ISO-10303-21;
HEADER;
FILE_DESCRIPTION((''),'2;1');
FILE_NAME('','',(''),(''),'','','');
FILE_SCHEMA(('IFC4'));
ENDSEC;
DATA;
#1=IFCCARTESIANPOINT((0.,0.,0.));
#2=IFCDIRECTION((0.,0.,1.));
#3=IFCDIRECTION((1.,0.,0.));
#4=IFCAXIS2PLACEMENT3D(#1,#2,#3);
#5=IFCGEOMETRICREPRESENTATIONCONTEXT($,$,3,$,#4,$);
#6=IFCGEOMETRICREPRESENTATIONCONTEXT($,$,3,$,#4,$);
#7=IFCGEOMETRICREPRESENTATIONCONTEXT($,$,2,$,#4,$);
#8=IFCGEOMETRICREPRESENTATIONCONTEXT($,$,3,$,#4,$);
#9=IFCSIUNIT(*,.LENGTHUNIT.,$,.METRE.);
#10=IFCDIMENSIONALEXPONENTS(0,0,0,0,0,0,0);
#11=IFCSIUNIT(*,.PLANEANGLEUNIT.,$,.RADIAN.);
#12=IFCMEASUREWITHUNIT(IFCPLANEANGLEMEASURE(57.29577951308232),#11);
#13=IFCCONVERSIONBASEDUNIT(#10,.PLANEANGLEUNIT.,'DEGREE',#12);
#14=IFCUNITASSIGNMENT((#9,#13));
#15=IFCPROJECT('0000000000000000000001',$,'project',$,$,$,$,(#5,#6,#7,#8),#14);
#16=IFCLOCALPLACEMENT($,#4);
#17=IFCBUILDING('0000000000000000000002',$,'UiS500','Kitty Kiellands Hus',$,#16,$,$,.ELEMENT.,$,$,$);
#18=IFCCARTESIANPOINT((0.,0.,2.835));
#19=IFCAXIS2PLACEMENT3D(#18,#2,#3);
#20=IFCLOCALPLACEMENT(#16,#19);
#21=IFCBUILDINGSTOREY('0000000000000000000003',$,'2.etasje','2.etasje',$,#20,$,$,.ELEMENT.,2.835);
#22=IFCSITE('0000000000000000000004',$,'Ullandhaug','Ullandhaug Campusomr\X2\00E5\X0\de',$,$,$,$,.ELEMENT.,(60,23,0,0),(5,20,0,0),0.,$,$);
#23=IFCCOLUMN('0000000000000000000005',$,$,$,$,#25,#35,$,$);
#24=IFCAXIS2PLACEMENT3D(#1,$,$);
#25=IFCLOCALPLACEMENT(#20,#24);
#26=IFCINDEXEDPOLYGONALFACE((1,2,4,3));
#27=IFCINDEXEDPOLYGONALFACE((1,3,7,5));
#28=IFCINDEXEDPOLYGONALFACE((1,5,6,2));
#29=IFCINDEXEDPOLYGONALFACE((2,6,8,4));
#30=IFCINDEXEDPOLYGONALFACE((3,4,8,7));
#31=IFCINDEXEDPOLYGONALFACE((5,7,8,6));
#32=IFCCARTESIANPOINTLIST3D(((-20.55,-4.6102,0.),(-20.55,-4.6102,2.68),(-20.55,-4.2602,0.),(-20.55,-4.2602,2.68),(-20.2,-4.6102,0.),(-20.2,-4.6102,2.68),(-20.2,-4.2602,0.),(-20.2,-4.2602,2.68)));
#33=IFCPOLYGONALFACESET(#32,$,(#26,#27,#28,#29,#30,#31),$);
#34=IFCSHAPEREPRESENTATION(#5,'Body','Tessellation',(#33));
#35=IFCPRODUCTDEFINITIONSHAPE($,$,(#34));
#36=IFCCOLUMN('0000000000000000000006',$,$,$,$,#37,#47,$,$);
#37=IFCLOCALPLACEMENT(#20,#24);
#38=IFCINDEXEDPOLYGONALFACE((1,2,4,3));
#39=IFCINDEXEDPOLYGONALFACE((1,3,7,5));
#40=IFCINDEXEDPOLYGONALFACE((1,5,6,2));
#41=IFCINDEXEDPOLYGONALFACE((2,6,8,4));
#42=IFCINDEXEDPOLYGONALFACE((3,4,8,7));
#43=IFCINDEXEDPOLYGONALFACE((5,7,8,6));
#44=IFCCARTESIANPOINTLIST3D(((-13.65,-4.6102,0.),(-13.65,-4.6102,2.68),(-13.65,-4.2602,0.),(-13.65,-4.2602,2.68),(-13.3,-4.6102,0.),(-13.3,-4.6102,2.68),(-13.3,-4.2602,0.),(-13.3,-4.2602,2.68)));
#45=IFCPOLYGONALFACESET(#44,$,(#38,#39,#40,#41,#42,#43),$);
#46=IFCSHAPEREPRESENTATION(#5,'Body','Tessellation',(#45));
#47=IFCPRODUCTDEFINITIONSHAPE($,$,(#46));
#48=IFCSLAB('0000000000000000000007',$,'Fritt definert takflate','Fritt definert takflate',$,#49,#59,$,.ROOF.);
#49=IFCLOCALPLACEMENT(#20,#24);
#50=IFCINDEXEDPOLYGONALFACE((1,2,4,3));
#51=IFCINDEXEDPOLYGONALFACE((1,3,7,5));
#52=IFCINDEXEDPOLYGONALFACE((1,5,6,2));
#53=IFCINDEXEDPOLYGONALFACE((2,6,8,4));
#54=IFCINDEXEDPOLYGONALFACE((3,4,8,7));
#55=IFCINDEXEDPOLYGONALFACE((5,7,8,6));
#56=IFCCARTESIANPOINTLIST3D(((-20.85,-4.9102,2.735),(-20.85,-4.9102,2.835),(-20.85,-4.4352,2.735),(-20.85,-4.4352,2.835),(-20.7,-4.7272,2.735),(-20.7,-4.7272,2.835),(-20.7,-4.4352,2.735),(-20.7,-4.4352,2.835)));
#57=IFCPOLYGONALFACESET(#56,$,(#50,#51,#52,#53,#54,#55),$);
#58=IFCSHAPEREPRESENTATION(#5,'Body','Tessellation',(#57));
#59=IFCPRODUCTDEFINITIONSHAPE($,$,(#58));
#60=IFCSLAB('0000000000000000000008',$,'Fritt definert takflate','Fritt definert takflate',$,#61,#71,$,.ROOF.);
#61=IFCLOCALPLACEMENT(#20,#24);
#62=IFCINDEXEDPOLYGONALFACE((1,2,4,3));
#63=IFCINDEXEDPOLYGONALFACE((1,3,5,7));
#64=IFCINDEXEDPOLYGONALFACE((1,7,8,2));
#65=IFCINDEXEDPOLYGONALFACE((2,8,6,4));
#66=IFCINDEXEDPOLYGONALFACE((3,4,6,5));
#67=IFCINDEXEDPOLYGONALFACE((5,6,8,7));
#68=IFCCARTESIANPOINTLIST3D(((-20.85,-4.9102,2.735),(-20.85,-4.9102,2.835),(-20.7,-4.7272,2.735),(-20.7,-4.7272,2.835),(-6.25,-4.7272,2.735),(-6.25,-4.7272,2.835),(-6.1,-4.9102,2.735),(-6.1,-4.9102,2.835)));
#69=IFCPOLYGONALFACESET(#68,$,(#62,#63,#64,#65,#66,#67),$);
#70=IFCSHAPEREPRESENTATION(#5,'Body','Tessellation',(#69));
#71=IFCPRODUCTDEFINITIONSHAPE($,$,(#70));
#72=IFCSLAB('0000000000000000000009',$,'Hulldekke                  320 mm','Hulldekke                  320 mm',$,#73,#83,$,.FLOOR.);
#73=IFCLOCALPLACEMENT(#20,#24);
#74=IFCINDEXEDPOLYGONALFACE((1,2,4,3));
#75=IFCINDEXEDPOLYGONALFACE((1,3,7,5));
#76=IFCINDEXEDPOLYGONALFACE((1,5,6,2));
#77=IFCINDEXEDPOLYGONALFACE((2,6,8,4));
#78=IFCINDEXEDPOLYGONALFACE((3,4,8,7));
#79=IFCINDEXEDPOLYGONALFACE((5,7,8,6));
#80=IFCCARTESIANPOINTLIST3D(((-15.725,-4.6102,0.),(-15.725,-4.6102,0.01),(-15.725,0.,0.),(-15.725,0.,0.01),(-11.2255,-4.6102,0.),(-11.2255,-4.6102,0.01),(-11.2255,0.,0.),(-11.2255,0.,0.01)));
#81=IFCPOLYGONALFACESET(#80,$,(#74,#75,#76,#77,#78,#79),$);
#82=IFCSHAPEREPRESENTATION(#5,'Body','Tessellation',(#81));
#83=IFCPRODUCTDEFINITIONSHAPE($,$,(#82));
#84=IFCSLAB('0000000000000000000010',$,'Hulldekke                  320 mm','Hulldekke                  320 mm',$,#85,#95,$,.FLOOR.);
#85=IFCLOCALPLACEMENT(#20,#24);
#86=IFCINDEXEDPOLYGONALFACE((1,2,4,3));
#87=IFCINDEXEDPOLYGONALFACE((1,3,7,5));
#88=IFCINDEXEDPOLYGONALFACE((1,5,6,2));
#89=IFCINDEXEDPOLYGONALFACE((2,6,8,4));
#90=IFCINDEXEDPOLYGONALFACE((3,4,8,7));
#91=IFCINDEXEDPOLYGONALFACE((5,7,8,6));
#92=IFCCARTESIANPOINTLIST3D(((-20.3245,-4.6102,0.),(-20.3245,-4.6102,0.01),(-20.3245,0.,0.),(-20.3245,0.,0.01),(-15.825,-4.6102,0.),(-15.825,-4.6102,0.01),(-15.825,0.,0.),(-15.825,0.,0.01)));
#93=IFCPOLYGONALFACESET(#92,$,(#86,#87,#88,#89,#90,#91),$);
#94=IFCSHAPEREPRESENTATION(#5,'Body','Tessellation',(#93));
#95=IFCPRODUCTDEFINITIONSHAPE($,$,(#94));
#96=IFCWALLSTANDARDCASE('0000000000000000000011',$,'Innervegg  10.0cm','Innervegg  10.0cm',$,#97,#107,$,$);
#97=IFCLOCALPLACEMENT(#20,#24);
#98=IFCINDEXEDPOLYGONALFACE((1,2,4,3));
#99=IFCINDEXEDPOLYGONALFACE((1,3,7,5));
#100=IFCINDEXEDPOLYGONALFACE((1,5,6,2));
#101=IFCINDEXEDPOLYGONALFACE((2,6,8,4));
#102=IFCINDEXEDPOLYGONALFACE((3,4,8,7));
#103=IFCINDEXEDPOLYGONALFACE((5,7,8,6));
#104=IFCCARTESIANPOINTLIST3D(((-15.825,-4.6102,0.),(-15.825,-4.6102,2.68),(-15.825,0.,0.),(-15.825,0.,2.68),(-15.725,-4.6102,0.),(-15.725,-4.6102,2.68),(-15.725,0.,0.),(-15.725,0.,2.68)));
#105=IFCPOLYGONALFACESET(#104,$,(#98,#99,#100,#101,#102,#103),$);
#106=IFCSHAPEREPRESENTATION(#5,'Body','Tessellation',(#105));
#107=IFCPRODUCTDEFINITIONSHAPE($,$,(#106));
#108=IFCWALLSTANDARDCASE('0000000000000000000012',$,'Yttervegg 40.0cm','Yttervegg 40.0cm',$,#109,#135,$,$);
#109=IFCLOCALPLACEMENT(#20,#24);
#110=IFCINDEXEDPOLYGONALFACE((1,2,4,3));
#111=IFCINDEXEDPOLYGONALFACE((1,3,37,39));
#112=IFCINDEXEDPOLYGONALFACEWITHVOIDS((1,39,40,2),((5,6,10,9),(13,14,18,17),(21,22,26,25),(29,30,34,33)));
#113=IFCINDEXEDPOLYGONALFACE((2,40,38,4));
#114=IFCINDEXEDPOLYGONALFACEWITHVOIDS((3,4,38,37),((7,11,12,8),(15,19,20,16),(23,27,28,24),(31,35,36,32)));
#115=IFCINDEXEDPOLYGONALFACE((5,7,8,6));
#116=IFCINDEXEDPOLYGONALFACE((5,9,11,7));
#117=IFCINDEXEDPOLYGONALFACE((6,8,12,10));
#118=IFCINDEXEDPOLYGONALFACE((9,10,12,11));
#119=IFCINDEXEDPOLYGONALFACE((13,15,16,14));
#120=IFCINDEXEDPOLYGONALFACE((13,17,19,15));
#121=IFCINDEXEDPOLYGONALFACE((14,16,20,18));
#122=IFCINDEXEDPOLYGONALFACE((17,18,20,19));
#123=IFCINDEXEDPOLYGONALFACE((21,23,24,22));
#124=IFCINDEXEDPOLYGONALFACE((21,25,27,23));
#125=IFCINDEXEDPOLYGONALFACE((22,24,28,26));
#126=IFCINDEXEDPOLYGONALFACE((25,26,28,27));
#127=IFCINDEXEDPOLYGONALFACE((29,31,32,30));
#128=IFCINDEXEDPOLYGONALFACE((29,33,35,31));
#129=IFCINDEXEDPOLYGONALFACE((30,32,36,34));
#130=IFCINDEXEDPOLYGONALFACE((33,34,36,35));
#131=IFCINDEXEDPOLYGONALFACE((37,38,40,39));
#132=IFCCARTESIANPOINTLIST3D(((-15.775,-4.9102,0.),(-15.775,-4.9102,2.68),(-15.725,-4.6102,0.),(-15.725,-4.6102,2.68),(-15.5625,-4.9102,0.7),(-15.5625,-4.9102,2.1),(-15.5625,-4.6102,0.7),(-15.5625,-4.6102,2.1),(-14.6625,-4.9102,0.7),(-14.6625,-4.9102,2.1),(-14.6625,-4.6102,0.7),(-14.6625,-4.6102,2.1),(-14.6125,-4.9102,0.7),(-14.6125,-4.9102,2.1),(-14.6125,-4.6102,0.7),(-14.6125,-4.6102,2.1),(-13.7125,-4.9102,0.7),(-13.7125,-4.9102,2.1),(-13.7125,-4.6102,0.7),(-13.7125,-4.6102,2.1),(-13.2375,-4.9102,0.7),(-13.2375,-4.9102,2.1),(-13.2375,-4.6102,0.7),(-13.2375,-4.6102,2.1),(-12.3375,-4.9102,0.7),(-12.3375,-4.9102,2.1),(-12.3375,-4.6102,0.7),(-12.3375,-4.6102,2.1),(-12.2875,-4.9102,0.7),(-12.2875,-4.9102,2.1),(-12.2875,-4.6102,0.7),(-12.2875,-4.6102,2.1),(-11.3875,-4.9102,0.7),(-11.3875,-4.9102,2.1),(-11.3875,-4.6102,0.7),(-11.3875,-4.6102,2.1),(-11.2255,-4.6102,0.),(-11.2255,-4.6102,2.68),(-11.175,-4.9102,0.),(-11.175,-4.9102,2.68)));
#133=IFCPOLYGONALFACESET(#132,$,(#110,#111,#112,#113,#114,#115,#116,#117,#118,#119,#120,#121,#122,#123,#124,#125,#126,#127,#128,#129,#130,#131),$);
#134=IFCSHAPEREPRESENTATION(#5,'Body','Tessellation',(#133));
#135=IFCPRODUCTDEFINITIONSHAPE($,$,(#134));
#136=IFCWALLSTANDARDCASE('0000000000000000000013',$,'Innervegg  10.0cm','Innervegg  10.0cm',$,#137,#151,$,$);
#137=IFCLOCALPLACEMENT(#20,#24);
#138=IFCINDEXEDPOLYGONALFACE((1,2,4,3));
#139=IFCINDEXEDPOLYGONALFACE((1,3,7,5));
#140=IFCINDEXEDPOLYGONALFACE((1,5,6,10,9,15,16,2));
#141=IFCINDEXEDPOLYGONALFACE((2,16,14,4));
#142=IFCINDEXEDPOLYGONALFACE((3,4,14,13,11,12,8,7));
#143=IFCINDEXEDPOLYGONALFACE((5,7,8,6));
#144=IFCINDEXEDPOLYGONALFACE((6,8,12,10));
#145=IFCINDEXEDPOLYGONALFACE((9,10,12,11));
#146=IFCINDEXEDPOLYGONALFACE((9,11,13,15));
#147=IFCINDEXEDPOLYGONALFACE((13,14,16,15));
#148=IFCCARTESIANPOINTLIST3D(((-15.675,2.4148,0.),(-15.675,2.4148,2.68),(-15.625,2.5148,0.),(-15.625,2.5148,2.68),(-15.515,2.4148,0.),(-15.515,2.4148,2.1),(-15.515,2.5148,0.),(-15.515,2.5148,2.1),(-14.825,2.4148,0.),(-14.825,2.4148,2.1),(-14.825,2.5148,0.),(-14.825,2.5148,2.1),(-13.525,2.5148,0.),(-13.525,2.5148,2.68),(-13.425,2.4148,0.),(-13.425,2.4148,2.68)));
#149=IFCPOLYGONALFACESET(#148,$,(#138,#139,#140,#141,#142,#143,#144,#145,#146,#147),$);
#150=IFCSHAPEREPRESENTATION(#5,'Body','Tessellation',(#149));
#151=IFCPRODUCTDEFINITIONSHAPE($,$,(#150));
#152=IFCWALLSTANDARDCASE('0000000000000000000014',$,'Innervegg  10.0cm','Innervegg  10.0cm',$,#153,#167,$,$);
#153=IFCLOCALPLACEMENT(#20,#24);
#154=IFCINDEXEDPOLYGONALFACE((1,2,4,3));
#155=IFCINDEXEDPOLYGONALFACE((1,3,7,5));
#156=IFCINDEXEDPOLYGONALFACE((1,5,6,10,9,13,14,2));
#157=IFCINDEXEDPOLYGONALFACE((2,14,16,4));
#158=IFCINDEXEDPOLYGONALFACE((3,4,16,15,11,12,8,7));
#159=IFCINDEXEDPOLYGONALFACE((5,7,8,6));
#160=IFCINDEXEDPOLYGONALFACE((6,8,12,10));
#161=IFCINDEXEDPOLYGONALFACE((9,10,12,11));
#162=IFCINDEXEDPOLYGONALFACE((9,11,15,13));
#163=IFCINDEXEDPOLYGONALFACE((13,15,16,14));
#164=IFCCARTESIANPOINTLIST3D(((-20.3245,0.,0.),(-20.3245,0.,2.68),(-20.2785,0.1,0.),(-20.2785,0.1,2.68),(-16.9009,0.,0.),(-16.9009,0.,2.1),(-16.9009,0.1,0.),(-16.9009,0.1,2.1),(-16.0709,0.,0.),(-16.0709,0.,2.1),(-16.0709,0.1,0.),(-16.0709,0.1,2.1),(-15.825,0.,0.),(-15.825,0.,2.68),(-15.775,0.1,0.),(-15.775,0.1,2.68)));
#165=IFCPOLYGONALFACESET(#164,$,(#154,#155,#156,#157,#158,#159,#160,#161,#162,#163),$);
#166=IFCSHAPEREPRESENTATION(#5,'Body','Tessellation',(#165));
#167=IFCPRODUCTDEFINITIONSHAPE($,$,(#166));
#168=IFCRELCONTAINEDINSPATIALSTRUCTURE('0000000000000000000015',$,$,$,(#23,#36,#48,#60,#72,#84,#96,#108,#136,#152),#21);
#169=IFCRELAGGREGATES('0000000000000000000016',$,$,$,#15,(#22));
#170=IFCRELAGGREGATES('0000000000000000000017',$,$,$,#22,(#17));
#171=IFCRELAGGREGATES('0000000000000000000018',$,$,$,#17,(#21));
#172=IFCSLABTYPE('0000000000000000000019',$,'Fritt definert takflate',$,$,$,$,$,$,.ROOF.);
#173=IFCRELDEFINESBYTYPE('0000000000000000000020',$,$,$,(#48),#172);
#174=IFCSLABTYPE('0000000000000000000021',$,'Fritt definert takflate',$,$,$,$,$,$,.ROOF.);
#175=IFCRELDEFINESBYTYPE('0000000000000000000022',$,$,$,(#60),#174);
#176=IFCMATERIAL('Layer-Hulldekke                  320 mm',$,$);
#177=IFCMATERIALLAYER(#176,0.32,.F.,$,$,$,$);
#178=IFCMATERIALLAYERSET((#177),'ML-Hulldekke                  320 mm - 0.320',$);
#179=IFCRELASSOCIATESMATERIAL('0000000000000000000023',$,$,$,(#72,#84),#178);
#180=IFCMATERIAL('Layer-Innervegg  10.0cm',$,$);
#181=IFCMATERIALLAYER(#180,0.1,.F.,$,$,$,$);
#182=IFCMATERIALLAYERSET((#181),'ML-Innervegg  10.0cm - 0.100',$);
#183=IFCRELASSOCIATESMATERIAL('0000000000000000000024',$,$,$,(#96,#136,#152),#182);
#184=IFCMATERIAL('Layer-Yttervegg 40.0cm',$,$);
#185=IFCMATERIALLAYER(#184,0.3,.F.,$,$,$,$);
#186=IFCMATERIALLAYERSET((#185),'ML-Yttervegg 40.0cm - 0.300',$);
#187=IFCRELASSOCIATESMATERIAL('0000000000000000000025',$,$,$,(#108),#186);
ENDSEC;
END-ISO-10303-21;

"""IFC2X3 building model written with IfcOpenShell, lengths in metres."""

from ifc_helpers import new_model, entity, si_unit, converted_unit, frame, origin_with_axes, origin_2d_with_axis, place, context, project, spatial, polyline, rectangle, outline, extrude, material, layer, layer_set, layer_usage, type_object, element, save


model = new_model("IFC2X3")

# Units and contexts
context_of_model_1 = context(None, 3, world=origin_with_axes())
context_of_model_2 = context(None, 3, world=origin_with_axes())
context_of_model_3 = context(None, 2, world=origin_with_axes())
context_of_model_4 = context(None, 3, world=origin_with_axes())
ifc_project = project(units=[si_unit("LENGTHUNIT", "METRE"), converted_unit("PLANEANGLEUNIT", "DEGREE", entity("IfcPlaneAngleMeasure", 57.29577951308232), si_unit("PLANEANGLEUNIT", "RADIAN"), dimensions=[0, 0, 0, 0, 0, 0, 0])], contexts=[context_of_model_1, context_of_model_2, context_of_model_3, context_of_model_4])

# Site, building, storey
site = spatial("IfcSite", under=ifc_project, Name="Ullandhaug", Description="Ullandhaug Campusområde", CompositionType="ELEMENT", RefLatitude=(60, 23, 0, 0), RefLongitude=(5, 20, 0, 0), RefElevation=0.0)
building_placement = place(None, origin_with_axes())
building = spatial("IfcBuilding", under=site, at=building_placement, Name="UiS500", Description="Kitty Kiellands Hus", CompositionType="ELEMENT")
storey_placement = place(building_placement, frame((0.0, 0.0, 2.835), z_axis=(0.0, 0.0, 1.0), x_axis=(1.0, 0.0, 0.0)))
storey = spatial("IfcBuildingStorey", under=building, at=storey_placement, Name="2.etasje", Description="2.etasje", CompositionType="ELEMENT", Elevation=2.835)

# Columns
for number, where, z_axis, x_axis in (
    (1, (-20.375, -4.4352, 0.0), (0.0, 0.0, 1.0), (1.0, 0.0, 0.0)),
    (2, (-13.475, -4.4352, 0.0), (0.0, 0.0, 1.0), (1.0, 0.0, 0.0)),
):
    element("IfcColumn", number, at=place(storey_placement, frame(where, z_axis=z_axis, x_axis=x_axis)), inside=storey, context=context_of_model_1, shape_type="SweptSolid", body=[
        extrude(rectangle(XDim=0.35, YDim=0.35, at=origin_2d_with_axis()), origin_with_axes(), (0.0, 0.0, 1.0), 2.68),
    ])

# Slabs
slab_type_1 = type_object("IfcSlabType", Name="Fritt definert takflate", PredefinedType="ROOF")
slab_1_placement = place(storey_placement, frame((-20.85, -4.9102, 2.735), z_axis=(0.0, 0.0, 1.0), x_axis=(0.633929, 0.773391, 0.0)))
element("IfcSlab", 3, at=slab_1_placement, inside=storey, type_object=slab_type_1, Name="Fritt definert takflate", Description="Fritt definert takflate", PredefinedType="ROOF", context=context_of_model_1, shape_type="SweptSolid", body=[
    extrude(outline(polyline([(0.0, 0.0), (0.2366, 0.0), (0.4624, 0.1851), (0.3674, 0.3011), (0.0, 0.0)])), frame((0.0, 0.0, 0.0), z_axis=(0.0, 0.0, 1.0), x_axis=(1.0, 0.0, 0.0)), (0.0, 0.0, 1.0), 0.1),
])
slab_type_2 = type_object("IfcSlabType", Name="Fritt definert takflate", PredefinedType="ROOF")
slab_2_placement = place(storey_placement, frame((-20.7, -4.7272, 2.735), z_axis=(0.0, 0.0, 1.0), x_axis=(-0.633929, -0.773391, 0.0)))
element("IfcSlab", 4, at=slab_2_placement, inside=storey, type_object=slab_type_2, Name="Fritt definert takflate", Description="Fritt definert takflate", PredefinedType="ROOF", context=context_of_model_1, shape_type="SweptSolid", body=[
    extrude(outline(polyline([(0.0, 0.0), (0.2366, 0.0), (-9.1138, 11.4075), (-9.1603, 11.1755), (0.0, 0.0)])), frame((0.0, 0.0, 0.0), z_axis=(0.0, 0.0, 1.0), x_axis=(1.0, 0.0, 0.0)), (0.0, 0.0, 1.0), 0.1),
])
ifc_material_1 = material(Name="Layer-Hulldekke                  320 mm")
ifc_layer_1 = layer(ifc_material_1, 0.32, ventilated=False)
ifc_layer_set_1 = layer_set([ifc_layer_1], Name="ML-Hulldekke                  320 mm - 0.320")
ifc_layer_usage_1 = layer_usage(ifc_layer_set_1, "AXIS2", "POSITIVE", 0.0)
slab_3_placement = place(storey_placement, frame((-15.725, 0.0, 0.0), z_axis=(0.0, 0.0, 1.0), x_axis=(1.0, 0.0, 0.0)))
element("IfcSlab", 5, at=slab_3_placement, inside=storey, material=ifc_layer_usage_1, Name="Hulldekke                  320 mm", Description="Hulldekke                  320 mm", PredefinedType="FLOOR", context=context_of_model_1, shape_type="SweptSolid", body=[
    extrude(outline(polyline([(0.0, 0.0), (4.6102, 0.0), (4.6102, 4.4995), (0.0, 4.4995), (0.0, 0.0)])), frame((0.0, 0.0, 0.0), z_axis=(0.0, 0.0, 1.0), x_axis=(0.0, -1.0, 0.0)), (0.0, 0.0, 1.0), 0.01),
])
slab_4_placement = place(storey_placement, frame((-15.825, -4.6102, 0.0), z_axis=(0.0, 0.0, 1.0), x_axis=(1.0, 0.0, 0.0)))
element("IfcSlab", 6, at=slab_4_placement, inside=storey, material=ifc_layer_usage_1, Name="Hulldekke                  320 mm", Description="Hulldekke                  320 mm", PredefinedType="FLOOR", context=context_of_model_1, shape_type="SweptSolid", body=[
    extrude(outline(polyline([(0.0, 0.0), (4.6102, 0.0), (4.6102, 4.4995), (0.0, 4.4995), (0.0, 0.0)])), frame((0.0, 0.0, 0.0), z_axis=(0.0, 0.0, 1.0), x_axis=(0.0, 1.0, 0.0)), (0.0, 0.0, 1.0), 0.01),
])

# Wall
ifc_material_2 = material(Name="Layer-Innervegg  10.0cm")
ifc_layer_2 = layer(ifc_material_2, 0.1, ventilated=False)
ifc_layer_set_2 = layer_set([ifc_layer_2], Name="ML-Innervegg  10.0cm - 0.100")
ifc_layer_usage_2 = layer_usage(ifc_layer_set_2, "AXIS2", "POSITIVE", 0.0)
wall_1_placement = place(storey_placement, frame((-15.825, 0.0, 0.0), z_axis=(0.0, 0.0, 1.0), x_axis=(0.0, -1.0, 0.0)))
element("IfcWallStandardCase", 7, at=wall_1_placement, inside=storey, material=ifc_layer_usage_2, Name="Innervegg  10.0cm", Description="Innervegg  10.0cm", context=context_of_model_1, shape_type="SweptSolid", body=[
    extrude(outline(polyline([(0.0, 0.0), (4.6102, 0.0), (4.6102, 0.1), (0.0, 0.1), (0.0, 0.0)])), frame((0.0, 0.0, 0.0), z_axis=(0.0, 0.0, 1.0), x_axis=(1.0, 0.0, 0.0)), (0.0, 0.0, 1.0), 2.68),
])

# Wall, openings
ifc_material_3 = material(Name="Layer-Yttervegg 40.0cm")
ifc_layer_3 = layer(ifc_material_3, 0.3, ventilated=False)
ifc_layer_set_3 = layer_set([ifc_layer_3], Name="ML-Yttervegg 40.0cm - 0.300")
ifc_layer_usage_3 = layer_usage(ifc_layer_set_3, "AXIS2", "POSITIVE", 0.0)
wall_2_placement = place(storey_placement, frame((-15.775, -4.9102, 0.0), z_axis=(0.0, 0.0, 1.0), x_axis=(1.0, 0.0, 0.0)))
wall_2 = element("IfcWallStandardCase", 8, at=wall_2_placement, inside=storey, material=ifc_layer_usage_3, Name="Yttervegg 40.0cm", Description="Yttervegg 40.0cm", context=context_of_model_1, shape_type="SweptSolid", body=[
    extrude(outline(polyline([(0.0, 0.0), (4.6, 0.0), (4.5495, 0.3), (0.05, 0.3), (0.0, 0.0)])), origin_with_axes(), (0.0, 0.0, 1.0), 2.68),
])
opening_1_placement = place(wall_2_placement, frame((0.2125, 0.3, 0.7), z_axis=(0.0, 0.0, 1.0), x_axis=(1.0, 0.0, 0.0)))
element("IfcOpeningElement", 9, at=opening_1_placement, cuts=wall_2, context=context_of_model_1, shape_type="SweptSolid", body=[
    extrude(outline(polyline([(0.0, 0.0), (1.4, 0.0), (1.4, 0.9), (0.0, 0.9), (0.0, 0.0)])), frame((0.0, 0.0, 0.0), z_axis=(0.0, 1.0, 0.0), x_axis=(0.0, 0.0, 1.0)), (0.0, 0.0, -1.0), 0.3),
])
opening_2_placement = place(wall_2_placement, frame((1.1625, 0.3, 0.7), z_axis=(0.0, 0.0, 1.0), x_axis=(1.0, 0.0, 0.0)))
element("IfcOpeningElement", 10, at=opening_2_placement, cuts=wall_2, context=context_of_model_1, shape_type="SweptSolid", body=[
    extrude(outline(polyline([(0.0, 0.0), (1.4, 0.0), (1.4, 0.9), (0.0, 0.9), (0.0, 0.0)])), frame((0.0, 0.0, 0.0), z_axis=(0.0, 1.0, 0.0), x_axis=(0.0, 0.0, 1.0)), (0.0, 0.0, -1.0), 0.3),
])
opening_3_placement = place(wall_2_placement, frame((2.5375, 0.3, 0.7), z_axis=(0.0, 0.0, 1.0), x_axis=(1.0, 0.0, 0.0)))
element("IfcOpeningElement", 11, at=opening_3_placement, cuts=wall_2, context=context_of_model_1, shape_type="SweptSolid", body=[
    extrude(outline(polyline([(0.0, 0.0), (1.4, 0.0), (1.4, 0.9), (0.0, 0.9), (0.0, 0.0)])), frame((0.0, 0.0, 0.0), z_axis=(0.0, 1.0, 0.0), x_axis=(0.0, 0.0, 1.0)), (0.0, 0.0, -1.0), 0.3),
])
opening_4_placement = place(wall_2_placement, frame((3.4875, 0.3, 0.7), z_axis=(0.0, 0.0, 1.0), x_axis=(1.0, 0.0, 0.0)))
element("IfcOpeningElement", 12, at=opening_4_placement, cuts=wall_2, context=context_of_model_1, shape_type="SweptSolid", body=[
    extrude(outline(polyline([(0.0, 0.0), (1.4, 0.0), (1.4, 0.9), (0.0, 0.9), (0.0, 0.0)])), frame((0.0, 0.0, 0.0), z_axis=(0.0, 1.0, 0.0), x_axis=(0.0, 0.0, 1.0)), (0.0, 0.0, -1.0), 0.3),
])

# Walls, openings
wall_3_placement = place(storey_placement, frame((-15.675, 2.4148, 0.0), z_axis=(0.0, 0.0, 1.0), x_axis=(1.0, 0.0, 0.0)))
wall_3 = element("IfcWallStandardCase", 13, at=wall_3_placement, inside=storey, material=ifc_layer_usage_2, Name="Innervegg  10.0cm", Description="Innervegg  10.0cm", context=context_of_model_1, shape_type="SweptSolid", body=[
    extrude(outline(polyline([(0.0, 0.0), (2.25, 0.0), (2.15, 0.1), (0.05, 0.1), (0.0, 0.0)])), origin_with_axes(), (0.0, 0.0, 1.0), 2.68),
])
opening_5_placement = place(wall_3_placement, frame((0.16, 0.1, 0.0), z_axis=(0.0, 0.0, 1.0), x_axis=(1.0, 0.0, 0.0)))
element("IfcOpeningElement", 14, at=opening_5_placement, cuts=wall_3, context=context_of_model_1, shape_type="SweptSolid", body=[
    extrude(outline(polyline([(0.0, 0.0), (2.1, 0.0), (2.1, 0.69), (0.0, 0.69), (0.0, 0.0)])), frame((0.0, 0.0, 0.0), z_axis=(0.0, 1.0, 0.0), x_axis=(0.0, 0.0, 1.0)), (0.0, 0.0, -1.0), 0.1),
])
wall_4_placement = place(storey_placement, frame((-15.775, 0.1, 0.0), z_axis=(0.0, 0.0, 1.0), x_axis=(-1.0, 0.0, 0.0)))
wall_4 = element("IfcWallStandardCase", 15, at=wall_4_placement, inside=storey, material=ifc_layer_usage_2, Name="Innervegg  10.0cm", Description="Innervegg  10.0cm", context=context_of_model_1, shape_type="SweptSolid", body=[
    extrude(outline(polyline([(0.0, 0.0), (4.5035, 0.0), (4.5495, 0.1), (0.05, 0.1), (0.0, 0.0)])), frame((0.0, 0.0, 0.0), z_axis=(0.0, 0.0, 1.0), x_axis=(1.0, 0.0, 0.0)), (0.0, 0.0, 1.0), 2.68),
])
opening_6_placement = place(wall_4_placement, frame((0.2959, 0.1, 0.0), z_axis=(0.0, 0.0, 1.0), x_axis=(1.0, 0.0, 0.0)))
element("IfcOpeningElement", 16, at=opening_6_placement, cuts=wall_4, context=context_of_model_1, shape_type="SweptSolid", body=[
    extrude(outline(polyline([(0.0, 0.0), (2.1, 0.0), (2.1, 0.83), (0.0, 0.83), (0.0, 0.0)])), frame((0.0, 0.0, 0.0), z_axis=(0.0, 1.0, 0.0), x_axis=(0.0, 0.0, 1.0)), (0.0, 0.0, -1.0), 0.1),
])

save(model, "model.ifc")
